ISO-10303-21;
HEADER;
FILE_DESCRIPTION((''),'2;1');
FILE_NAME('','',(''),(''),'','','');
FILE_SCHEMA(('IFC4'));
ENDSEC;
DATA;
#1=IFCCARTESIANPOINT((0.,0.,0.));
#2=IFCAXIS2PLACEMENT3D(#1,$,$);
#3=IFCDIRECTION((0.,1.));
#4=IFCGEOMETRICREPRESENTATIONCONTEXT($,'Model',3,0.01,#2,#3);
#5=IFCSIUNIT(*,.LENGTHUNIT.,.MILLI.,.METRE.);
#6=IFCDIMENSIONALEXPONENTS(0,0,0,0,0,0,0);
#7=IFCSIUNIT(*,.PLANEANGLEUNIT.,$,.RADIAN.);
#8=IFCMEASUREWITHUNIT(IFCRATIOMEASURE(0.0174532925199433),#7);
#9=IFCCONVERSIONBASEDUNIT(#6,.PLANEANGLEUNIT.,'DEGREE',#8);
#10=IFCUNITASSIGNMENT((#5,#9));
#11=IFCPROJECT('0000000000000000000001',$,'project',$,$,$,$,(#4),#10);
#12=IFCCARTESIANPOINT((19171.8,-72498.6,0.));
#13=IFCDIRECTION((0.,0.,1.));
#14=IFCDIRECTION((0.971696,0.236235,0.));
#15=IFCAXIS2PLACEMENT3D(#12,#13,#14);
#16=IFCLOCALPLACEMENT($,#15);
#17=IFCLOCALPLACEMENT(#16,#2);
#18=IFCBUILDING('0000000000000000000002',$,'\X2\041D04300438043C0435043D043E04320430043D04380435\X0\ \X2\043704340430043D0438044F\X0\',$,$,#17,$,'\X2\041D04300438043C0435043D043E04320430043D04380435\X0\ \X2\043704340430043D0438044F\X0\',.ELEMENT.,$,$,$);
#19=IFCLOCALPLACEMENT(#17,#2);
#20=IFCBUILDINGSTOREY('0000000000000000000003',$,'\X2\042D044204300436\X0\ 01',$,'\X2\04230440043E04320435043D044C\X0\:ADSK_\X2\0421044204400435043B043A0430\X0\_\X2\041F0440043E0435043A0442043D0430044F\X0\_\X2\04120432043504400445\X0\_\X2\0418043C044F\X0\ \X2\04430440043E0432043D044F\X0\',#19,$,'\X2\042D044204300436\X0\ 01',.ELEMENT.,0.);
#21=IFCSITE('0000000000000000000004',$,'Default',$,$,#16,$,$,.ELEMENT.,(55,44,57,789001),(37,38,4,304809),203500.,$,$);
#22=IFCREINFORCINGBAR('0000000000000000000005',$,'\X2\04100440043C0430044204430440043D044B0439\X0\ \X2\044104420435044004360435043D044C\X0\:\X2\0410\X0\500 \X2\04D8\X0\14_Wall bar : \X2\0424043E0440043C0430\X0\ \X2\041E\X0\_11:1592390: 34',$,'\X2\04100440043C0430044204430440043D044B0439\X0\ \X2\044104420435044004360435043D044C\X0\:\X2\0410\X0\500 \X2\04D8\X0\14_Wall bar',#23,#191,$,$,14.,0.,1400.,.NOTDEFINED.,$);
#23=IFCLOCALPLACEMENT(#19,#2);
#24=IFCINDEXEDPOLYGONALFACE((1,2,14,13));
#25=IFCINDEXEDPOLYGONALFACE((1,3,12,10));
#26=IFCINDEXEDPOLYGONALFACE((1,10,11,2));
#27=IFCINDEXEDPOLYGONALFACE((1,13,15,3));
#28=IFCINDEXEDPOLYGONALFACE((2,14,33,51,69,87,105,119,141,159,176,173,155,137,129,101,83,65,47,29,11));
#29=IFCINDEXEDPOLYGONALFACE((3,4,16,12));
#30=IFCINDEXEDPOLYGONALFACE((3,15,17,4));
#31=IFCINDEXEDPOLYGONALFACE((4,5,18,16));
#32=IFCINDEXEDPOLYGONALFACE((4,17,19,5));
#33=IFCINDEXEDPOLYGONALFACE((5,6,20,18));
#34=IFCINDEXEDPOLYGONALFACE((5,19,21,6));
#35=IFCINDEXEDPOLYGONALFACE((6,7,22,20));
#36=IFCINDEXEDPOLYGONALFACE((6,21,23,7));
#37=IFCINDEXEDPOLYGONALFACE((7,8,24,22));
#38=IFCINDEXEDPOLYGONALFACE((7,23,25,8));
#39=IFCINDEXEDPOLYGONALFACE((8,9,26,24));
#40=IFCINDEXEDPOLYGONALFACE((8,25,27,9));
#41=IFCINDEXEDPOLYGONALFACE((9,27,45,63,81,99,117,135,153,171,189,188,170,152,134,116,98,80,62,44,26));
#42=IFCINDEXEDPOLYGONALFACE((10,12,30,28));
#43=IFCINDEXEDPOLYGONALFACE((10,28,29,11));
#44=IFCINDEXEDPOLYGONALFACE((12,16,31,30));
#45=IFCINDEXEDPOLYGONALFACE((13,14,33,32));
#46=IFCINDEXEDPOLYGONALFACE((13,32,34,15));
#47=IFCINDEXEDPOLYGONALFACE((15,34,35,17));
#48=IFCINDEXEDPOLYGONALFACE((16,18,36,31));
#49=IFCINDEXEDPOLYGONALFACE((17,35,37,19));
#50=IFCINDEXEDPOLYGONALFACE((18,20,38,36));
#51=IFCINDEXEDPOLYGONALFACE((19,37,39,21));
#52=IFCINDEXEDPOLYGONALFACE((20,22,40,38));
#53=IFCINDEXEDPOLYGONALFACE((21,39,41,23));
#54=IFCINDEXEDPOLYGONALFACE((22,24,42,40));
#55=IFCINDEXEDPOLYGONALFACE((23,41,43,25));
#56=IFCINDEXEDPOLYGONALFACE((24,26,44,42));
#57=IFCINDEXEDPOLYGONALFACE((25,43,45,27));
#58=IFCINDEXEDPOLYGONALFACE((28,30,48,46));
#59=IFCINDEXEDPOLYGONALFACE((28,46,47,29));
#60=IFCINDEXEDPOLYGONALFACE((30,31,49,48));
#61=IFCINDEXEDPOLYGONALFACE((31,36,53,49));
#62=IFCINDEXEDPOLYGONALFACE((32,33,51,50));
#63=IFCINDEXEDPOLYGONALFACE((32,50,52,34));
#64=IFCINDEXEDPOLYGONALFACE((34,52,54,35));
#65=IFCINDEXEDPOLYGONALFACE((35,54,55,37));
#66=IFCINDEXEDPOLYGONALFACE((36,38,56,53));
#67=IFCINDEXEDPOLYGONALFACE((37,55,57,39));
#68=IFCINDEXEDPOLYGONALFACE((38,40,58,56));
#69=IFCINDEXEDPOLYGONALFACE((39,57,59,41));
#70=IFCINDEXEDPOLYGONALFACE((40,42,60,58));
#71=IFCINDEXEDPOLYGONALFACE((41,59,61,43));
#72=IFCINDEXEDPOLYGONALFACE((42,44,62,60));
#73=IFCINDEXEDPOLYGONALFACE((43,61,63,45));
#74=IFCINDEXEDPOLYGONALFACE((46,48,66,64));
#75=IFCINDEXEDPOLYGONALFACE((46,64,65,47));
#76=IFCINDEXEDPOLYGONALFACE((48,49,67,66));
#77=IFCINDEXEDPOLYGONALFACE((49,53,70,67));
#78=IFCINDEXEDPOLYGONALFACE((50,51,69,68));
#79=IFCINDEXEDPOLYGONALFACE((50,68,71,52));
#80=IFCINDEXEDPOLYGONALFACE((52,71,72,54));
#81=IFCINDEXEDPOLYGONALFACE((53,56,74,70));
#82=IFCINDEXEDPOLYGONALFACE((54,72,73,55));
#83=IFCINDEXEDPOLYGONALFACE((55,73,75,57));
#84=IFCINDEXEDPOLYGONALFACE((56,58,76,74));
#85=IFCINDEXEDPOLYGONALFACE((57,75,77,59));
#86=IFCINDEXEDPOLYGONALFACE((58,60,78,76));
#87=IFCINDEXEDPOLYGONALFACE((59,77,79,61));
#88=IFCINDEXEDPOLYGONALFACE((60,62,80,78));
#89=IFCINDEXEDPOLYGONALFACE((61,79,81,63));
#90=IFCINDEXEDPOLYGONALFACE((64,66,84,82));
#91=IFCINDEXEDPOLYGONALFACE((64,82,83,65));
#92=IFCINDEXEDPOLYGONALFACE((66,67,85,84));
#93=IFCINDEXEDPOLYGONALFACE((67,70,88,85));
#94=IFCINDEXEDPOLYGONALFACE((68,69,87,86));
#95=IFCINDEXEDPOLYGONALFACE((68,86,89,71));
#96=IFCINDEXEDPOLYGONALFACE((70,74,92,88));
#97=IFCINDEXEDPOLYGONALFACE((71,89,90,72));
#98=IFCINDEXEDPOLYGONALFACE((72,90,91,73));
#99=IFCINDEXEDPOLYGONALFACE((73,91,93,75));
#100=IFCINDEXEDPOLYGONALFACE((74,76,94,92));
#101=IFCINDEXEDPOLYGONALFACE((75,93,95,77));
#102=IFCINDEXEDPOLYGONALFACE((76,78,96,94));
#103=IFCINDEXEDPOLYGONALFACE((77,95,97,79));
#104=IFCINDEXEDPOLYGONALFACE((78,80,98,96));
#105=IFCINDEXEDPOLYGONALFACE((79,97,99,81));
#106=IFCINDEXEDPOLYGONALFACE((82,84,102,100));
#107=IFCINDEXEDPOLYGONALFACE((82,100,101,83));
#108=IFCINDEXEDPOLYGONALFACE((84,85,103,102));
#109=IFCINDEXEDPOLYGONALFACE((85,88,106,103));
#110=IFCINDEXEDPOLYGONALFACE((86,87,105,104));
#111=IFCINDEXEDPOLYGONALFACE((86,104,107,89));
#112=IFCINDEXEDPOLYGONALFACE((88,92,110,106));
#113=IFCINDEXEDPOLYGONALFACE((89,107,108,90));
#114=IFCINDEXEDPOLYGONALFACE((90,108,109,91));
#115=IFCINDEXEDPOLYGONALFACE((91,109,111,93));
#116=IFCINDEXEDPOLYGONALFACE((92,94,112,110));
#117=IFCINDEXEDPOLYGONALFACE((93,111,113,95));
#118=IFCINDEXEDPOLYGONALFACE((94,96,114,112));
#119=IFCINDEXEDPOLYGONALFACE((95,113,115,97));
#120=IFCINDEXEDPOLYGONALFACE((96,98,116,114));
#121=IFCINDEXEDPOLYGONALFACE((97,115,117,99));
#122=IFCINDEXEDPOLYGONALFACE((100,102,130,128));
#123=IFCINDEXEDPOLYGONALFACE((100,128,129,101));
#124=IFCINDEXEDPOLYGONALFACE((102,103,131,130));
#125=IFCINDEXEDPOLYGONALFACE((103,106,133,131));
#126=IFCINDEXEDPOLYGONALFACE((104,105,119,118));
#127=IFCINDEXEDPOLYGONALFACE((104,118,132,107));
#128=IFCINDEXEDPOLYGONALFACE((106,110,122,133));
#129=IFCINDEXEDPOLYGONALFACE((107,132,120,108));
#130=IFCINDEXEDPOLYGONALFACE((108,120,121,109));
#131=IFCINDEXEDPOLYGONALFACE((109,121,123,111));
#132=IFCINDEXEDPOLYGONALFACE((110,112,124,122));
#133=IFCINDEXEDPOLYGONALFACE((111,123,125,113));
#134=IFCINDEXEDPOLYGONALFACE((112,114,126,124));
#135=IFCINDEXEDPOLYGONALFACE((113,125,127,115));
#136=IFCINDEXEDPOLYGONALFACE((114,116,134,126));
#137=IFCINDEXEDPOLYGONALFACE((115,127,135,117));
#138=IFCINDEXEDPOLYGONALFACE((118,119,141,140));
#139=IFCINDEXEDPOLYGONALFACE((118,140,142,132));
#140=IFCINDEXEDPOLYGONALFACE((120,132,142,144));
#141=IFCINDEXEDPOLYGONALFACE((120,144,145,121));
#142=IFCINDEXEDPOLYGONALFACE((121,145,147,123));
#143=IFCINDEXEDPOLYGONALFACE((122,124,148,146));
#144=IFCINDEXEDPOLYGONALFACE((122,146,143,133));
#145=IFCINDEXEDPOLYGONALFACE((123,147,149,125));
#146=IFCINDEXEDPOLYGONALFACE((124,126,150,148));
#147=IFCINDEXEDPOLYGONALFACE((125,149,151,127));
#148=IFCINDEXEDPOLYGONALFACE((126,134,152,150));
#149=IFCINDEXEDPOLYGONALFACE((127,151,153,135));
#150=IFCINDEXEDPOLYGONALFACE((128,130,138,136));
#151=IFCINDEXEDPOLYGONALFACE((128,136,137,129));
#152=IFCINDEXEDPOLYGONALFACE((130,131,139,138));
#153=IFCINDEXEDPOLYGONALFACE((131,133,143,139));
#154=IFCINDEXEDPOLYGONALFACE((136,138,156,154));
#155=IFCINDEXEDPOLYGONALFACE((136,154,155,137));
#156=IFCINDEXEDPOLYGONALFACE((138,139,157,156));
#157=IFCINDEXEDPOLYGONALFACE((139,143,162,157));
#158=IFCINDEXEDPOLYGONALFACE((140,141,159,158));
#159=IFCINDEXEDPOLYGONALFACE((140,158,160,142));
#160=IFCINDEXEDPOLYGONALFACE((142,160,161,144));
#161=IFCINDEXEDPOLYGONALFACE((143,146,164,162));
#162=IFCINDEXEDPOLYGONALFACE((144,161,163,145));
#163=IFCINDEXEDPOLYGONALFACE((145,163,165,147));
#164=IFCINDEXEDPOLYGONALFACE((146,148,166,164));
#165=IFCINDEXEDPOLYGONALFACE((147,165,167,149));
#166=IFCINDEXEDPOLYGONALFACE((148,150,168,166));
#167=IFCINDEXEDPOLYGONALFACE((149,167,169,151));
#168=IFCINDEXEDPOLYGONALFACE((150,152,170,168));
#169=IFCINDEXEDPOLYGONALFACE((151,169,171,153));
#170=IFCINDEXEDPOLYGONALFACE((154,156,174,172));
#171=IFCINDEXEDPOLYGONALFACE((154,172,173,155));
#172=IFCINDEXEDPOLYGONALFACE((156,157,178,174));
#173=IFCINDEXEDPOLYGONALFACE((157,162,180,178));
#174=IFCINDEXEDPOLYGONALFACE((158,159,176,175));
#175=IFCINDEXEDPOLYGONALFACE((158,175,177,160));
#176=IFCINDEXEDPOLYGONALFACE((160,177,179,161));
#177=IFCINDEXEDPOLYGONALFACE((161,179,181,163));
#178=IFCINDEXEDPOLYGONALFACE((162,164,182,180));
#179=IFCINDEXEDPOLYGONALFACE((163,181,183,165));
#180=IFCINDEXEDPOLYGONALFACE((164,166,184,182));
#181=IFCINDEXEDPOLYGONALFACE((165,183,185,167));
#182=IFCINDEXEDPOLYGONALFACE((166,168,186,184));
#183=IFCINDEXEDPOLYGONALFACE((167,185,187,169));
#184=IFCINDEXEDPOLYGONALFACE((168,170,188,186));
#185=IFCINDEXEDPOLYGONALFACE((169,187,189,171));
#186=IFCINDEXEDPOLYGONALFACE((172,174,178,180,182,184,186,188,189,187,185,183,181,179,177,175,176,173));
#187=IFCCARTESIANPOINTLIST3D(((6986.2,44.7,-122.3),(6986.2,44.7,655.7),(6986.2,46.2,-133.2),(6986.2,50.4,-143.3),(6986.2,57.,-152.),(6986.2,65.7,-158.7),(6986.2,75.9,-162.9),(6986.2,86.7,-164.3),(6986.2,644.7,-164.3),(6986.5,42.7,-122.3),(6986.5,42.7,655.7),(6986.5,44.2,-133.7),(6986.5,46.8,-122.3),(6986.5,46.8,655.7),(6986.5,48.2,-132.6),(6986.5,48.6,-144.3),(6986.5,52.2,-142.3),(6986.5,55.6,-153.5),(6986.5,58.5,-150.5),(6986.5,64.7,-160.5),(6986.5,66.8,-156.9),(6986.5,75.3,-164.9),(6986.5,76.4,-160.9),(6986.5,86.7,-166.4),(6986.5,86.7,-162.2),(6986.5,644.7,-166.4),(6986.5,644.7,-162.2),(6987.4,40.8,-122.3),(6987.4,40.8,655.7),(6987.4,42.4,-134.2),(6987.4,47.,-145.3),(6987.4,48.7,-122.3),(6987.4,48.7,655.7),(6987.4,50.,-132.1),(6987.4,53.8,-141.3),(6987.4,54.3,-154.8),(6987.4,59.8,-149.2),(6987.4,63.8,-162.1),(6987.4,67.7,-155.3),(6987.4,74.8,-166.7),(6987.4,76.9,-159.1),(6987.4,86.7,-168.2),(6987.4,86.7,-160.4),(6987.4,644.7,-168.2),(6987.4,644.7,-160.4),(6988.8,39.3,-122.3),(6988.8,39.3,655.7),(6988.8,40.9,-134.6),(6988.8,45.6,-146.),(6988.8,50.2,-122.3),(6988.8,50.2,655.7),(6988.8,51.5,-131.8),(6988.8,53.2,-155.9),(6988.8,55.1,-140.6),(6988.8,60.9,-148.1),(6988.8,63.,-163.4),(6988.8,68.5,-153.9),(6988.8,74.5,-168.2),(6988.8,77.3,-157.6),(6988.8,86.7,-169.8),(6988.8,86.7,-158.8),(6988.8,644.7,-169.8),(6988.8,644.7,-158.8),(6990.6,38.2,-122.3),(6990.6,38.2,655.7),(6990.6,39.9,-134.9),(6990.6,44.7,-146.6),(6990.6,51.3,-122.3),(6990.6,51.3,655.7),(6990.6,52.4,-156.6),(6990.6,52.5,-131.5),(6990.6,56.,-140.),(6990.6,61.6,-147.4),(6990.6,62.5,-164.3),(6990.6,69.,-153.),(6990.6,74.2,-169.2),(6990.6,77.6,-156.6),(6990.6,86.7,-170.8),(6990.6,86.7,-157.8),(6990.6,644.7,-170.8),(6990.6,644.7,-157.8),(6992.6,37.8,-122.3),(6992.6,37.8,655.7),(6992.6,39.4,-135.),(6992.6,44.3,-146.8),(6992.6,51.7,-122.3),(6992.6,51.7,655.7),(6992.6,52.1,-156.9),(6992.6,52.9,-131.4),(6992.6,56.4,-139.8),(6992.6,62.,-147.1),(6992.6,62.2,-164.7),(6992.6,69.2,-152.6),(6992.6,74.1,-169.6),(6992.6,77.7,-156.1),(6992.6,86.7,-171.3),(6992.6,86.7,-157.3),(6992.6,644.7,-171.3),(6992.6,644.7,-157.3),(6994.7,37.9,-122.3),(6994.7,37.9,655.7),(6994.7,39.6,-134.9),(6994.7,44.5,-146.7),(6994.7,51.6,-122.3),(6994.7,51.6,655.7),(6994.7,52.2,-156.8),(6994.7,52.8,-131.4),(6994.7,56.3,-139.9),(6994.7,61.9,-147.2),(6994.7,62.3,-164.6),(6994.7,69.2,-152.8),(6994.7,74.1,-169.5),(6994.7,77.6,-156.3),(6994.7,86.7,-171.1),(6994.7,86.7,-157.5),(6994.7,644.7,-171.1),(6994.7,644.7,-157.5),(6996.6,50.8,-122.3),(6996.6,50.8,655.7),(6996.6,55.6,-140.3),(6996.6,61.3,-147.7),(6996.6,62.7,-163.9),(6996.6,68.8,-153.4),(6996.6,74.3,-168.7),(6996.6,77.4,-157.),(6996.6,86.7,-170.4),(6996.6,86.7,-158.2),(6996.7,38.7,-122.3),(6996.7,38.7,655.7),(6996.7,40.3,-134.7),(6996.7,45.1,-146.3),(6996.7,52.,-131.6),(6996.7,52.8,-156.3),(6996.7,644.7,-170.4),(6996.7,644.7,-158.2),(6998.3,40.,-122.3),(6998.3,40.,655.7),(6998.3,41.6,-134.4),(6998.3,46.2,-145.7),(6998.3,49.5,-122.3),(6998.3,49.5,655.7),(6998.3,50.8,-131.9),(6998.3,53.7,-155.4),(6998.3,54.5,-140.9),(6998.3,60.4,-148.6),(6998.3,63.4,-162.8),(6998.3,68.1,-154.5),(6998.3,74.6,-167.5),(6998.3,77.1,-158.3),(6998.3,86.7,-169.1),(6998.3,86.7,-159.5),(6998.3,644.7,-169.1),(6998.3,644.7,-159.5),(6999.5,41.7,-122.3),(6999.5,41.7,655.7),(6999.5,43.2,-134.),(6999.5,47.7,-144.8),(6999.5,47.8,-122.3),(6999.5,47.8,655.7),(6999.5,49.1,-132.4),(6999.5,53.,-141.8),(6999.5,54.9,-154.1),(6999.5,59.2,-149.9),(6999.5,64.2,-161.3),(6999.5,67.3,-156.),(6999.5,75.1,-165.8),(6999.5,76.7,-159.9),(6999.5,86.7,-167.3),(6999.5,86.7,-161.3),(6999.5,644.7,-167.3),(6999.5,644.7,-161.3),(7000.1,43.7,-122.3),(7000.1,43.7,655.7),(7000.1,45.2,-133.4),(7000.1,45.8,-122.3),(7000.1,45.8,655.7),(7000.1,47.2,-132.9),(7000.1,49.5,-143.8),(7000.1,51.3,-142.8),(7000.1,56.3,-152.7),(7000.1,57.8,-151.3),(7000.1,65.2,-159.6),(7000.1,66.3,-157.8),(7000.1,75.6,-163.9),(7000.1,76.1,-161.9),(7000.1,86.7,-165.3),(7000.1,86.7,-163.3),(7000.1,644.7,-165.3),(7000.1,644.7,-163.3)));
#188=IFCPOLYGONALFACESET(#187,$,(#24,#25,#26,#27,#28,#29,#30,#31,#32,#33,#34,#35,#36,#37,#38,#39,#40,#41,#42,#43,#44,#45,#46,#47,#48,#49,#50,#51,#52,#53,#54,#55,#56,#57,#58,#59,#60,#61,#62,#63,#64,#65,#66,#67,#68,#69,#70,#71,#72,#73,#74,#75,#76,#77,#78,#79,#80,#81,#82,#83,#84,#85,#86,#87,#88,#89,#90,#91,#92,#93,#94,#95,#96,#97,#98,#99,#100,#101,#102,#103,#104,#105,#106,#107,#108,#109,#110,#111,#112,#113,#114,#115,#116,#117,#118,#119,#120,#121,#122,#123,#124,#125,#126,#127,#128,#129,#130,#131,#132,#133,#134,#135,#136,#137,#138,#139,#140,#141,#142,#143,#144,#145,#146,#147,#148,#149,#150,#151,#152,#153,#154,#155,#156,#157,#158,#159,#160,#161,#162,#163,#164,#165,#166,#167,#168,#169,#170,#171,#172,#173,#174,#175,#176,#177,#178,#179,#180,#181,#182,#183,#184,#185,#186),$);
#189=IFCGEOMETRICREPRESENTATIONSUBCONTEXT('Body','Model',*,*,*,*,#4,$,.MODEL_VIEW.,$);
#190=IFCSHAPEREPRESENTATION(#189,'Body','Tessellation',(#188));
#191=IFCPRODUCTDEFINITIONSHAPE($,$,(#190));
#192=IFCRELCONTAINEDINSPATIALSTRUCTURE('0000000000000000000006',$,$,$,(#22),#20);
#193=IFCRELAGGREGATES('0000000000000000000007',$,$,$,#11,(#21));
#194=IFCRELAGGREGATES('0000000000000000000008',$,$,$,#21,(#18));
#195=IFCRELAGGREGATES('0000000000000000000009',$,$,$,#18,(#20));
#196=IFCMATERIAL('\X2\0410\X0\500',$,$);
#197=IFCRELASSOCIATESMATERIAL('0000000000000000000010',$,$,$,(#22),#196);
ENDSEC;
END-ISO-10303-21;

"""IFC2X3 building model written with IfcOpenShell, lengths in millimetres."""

from ifc_helpers import new_model, entity, si_unit, converted_unit, direction, frame, origin, place, context, subcontext, project, spatial, material, element, save


model = new_model("IFC2X3")

# Units and contexts
model_context = context("Model", 3, precision=0.01, world=origin(), true_north=direction((0.0, 1.0)))
body_context = subcontext(model_context, "Body", "Model", "MODEL_VIEW")
ifc_project = project(units=[si_unit("LENGTHUNIT", "METRE", prefix="MILLI"), converted_unit("PLANEANGLEUNIT", "DEGREE", entity("IfcRatioMeasure", 0.0174532925199433), si_unit("PLANEANGLEUNIT", "RADIAN"), dimensions=[0, 0, 0, 0, 0, 0, 0])], contexts=[model_context])

# Site, building, storey
site_placement = place(None, frame((19171.8, -72498.6, 0.0), z_axis=(0.0, 0.0, 1.0), x_axis=(0.971696, 0.236235, 0.0)))
site = spatial("IfcSite", under=ifc_project, at=site_placement, Name="Default", CompositionType="ELEMENT", RefLatitude=(55, 44, 57, 789001), RefLongitude=(37, 38, 4, 304809), RefElevation=203500.0)
building_placement = place(site_placement, origin())
building = spatial("IfcBuilding", under=site, at=building_placement, Name="Наименование здания", LongName="Наименование здания", CompositionType="ELEMENT")
storey_placement = place(building_placement, origin())
storey = spatial("IfcBuildingStorey", under=building, at=storey_placement, Name="Этаж 01", ObjectType="Уровень:ADSK_Стрелка_Проектная_Вверх_Имя уровня", LongName="Этаж 01", CompositionType="ELEMENT", Elevation=0.0)

# Reinforcing bar
ifc_material = material(Name="А500")
placement = place(storey_placement, origin())
element("IfcReinforcingBar", 1, at=placement, inside=storey, material=ifc_material, Name="Арматурный стержень:А500 Ә14_Wall bar : Форма О_11:1592390: 34", ObjectType="Арматурный стержень:А500 Ә14_Wall bar", BarLength=1400.0, BarRole="NOTDEFINED", CrossSectionArea=0.0, NominalDiameter=14.0, context=body_context, shape_type="AdvancedSweptSolid", body=[
    entity("IfcSweptDiskSolid", entity("IfcCompositeCurve", [entity("IfcCompositeCurveSegment", "CONTINUOUS", True, entity("IfcPolyline", [entity("IfcCartesianPoint", [6993.1, 44.7, 655.7]), entity("IfcCartesianPoint", [6993.1, 44.7, -122.3])])), entity("IfcCompositeCurveSegment", "CONTINUOUS", True, entity("IfcTrimmedCurve", entity("IfcCircle", entity("IfcAxis2Placement3D", entity("IfcCartesianPoint", [6993.1, 86.7, -122.3]), entity("IfcDirection", [1.0, 0.0, 0.0]), entity("IfcDirection", [0.0, 0.0, -1.0])), 42.0), [entity("IfcParameterValue", 270.0)], [entity("IfcParameterValue", 360.0)], True, "PARAMETER")), entity("IfcCompositeCurveSegment", "CONTINUOUS", True, entity("IfcPolyline", [entity("IfcCartesianPoint", [6993.1, 86.7, -164.3]), entity("IfcCartesianPoint", [6993.1, 644.7, -164.3])]))], False), 7.0, None, 0.0, 92.0),
])

save(model, "model.ifc")
